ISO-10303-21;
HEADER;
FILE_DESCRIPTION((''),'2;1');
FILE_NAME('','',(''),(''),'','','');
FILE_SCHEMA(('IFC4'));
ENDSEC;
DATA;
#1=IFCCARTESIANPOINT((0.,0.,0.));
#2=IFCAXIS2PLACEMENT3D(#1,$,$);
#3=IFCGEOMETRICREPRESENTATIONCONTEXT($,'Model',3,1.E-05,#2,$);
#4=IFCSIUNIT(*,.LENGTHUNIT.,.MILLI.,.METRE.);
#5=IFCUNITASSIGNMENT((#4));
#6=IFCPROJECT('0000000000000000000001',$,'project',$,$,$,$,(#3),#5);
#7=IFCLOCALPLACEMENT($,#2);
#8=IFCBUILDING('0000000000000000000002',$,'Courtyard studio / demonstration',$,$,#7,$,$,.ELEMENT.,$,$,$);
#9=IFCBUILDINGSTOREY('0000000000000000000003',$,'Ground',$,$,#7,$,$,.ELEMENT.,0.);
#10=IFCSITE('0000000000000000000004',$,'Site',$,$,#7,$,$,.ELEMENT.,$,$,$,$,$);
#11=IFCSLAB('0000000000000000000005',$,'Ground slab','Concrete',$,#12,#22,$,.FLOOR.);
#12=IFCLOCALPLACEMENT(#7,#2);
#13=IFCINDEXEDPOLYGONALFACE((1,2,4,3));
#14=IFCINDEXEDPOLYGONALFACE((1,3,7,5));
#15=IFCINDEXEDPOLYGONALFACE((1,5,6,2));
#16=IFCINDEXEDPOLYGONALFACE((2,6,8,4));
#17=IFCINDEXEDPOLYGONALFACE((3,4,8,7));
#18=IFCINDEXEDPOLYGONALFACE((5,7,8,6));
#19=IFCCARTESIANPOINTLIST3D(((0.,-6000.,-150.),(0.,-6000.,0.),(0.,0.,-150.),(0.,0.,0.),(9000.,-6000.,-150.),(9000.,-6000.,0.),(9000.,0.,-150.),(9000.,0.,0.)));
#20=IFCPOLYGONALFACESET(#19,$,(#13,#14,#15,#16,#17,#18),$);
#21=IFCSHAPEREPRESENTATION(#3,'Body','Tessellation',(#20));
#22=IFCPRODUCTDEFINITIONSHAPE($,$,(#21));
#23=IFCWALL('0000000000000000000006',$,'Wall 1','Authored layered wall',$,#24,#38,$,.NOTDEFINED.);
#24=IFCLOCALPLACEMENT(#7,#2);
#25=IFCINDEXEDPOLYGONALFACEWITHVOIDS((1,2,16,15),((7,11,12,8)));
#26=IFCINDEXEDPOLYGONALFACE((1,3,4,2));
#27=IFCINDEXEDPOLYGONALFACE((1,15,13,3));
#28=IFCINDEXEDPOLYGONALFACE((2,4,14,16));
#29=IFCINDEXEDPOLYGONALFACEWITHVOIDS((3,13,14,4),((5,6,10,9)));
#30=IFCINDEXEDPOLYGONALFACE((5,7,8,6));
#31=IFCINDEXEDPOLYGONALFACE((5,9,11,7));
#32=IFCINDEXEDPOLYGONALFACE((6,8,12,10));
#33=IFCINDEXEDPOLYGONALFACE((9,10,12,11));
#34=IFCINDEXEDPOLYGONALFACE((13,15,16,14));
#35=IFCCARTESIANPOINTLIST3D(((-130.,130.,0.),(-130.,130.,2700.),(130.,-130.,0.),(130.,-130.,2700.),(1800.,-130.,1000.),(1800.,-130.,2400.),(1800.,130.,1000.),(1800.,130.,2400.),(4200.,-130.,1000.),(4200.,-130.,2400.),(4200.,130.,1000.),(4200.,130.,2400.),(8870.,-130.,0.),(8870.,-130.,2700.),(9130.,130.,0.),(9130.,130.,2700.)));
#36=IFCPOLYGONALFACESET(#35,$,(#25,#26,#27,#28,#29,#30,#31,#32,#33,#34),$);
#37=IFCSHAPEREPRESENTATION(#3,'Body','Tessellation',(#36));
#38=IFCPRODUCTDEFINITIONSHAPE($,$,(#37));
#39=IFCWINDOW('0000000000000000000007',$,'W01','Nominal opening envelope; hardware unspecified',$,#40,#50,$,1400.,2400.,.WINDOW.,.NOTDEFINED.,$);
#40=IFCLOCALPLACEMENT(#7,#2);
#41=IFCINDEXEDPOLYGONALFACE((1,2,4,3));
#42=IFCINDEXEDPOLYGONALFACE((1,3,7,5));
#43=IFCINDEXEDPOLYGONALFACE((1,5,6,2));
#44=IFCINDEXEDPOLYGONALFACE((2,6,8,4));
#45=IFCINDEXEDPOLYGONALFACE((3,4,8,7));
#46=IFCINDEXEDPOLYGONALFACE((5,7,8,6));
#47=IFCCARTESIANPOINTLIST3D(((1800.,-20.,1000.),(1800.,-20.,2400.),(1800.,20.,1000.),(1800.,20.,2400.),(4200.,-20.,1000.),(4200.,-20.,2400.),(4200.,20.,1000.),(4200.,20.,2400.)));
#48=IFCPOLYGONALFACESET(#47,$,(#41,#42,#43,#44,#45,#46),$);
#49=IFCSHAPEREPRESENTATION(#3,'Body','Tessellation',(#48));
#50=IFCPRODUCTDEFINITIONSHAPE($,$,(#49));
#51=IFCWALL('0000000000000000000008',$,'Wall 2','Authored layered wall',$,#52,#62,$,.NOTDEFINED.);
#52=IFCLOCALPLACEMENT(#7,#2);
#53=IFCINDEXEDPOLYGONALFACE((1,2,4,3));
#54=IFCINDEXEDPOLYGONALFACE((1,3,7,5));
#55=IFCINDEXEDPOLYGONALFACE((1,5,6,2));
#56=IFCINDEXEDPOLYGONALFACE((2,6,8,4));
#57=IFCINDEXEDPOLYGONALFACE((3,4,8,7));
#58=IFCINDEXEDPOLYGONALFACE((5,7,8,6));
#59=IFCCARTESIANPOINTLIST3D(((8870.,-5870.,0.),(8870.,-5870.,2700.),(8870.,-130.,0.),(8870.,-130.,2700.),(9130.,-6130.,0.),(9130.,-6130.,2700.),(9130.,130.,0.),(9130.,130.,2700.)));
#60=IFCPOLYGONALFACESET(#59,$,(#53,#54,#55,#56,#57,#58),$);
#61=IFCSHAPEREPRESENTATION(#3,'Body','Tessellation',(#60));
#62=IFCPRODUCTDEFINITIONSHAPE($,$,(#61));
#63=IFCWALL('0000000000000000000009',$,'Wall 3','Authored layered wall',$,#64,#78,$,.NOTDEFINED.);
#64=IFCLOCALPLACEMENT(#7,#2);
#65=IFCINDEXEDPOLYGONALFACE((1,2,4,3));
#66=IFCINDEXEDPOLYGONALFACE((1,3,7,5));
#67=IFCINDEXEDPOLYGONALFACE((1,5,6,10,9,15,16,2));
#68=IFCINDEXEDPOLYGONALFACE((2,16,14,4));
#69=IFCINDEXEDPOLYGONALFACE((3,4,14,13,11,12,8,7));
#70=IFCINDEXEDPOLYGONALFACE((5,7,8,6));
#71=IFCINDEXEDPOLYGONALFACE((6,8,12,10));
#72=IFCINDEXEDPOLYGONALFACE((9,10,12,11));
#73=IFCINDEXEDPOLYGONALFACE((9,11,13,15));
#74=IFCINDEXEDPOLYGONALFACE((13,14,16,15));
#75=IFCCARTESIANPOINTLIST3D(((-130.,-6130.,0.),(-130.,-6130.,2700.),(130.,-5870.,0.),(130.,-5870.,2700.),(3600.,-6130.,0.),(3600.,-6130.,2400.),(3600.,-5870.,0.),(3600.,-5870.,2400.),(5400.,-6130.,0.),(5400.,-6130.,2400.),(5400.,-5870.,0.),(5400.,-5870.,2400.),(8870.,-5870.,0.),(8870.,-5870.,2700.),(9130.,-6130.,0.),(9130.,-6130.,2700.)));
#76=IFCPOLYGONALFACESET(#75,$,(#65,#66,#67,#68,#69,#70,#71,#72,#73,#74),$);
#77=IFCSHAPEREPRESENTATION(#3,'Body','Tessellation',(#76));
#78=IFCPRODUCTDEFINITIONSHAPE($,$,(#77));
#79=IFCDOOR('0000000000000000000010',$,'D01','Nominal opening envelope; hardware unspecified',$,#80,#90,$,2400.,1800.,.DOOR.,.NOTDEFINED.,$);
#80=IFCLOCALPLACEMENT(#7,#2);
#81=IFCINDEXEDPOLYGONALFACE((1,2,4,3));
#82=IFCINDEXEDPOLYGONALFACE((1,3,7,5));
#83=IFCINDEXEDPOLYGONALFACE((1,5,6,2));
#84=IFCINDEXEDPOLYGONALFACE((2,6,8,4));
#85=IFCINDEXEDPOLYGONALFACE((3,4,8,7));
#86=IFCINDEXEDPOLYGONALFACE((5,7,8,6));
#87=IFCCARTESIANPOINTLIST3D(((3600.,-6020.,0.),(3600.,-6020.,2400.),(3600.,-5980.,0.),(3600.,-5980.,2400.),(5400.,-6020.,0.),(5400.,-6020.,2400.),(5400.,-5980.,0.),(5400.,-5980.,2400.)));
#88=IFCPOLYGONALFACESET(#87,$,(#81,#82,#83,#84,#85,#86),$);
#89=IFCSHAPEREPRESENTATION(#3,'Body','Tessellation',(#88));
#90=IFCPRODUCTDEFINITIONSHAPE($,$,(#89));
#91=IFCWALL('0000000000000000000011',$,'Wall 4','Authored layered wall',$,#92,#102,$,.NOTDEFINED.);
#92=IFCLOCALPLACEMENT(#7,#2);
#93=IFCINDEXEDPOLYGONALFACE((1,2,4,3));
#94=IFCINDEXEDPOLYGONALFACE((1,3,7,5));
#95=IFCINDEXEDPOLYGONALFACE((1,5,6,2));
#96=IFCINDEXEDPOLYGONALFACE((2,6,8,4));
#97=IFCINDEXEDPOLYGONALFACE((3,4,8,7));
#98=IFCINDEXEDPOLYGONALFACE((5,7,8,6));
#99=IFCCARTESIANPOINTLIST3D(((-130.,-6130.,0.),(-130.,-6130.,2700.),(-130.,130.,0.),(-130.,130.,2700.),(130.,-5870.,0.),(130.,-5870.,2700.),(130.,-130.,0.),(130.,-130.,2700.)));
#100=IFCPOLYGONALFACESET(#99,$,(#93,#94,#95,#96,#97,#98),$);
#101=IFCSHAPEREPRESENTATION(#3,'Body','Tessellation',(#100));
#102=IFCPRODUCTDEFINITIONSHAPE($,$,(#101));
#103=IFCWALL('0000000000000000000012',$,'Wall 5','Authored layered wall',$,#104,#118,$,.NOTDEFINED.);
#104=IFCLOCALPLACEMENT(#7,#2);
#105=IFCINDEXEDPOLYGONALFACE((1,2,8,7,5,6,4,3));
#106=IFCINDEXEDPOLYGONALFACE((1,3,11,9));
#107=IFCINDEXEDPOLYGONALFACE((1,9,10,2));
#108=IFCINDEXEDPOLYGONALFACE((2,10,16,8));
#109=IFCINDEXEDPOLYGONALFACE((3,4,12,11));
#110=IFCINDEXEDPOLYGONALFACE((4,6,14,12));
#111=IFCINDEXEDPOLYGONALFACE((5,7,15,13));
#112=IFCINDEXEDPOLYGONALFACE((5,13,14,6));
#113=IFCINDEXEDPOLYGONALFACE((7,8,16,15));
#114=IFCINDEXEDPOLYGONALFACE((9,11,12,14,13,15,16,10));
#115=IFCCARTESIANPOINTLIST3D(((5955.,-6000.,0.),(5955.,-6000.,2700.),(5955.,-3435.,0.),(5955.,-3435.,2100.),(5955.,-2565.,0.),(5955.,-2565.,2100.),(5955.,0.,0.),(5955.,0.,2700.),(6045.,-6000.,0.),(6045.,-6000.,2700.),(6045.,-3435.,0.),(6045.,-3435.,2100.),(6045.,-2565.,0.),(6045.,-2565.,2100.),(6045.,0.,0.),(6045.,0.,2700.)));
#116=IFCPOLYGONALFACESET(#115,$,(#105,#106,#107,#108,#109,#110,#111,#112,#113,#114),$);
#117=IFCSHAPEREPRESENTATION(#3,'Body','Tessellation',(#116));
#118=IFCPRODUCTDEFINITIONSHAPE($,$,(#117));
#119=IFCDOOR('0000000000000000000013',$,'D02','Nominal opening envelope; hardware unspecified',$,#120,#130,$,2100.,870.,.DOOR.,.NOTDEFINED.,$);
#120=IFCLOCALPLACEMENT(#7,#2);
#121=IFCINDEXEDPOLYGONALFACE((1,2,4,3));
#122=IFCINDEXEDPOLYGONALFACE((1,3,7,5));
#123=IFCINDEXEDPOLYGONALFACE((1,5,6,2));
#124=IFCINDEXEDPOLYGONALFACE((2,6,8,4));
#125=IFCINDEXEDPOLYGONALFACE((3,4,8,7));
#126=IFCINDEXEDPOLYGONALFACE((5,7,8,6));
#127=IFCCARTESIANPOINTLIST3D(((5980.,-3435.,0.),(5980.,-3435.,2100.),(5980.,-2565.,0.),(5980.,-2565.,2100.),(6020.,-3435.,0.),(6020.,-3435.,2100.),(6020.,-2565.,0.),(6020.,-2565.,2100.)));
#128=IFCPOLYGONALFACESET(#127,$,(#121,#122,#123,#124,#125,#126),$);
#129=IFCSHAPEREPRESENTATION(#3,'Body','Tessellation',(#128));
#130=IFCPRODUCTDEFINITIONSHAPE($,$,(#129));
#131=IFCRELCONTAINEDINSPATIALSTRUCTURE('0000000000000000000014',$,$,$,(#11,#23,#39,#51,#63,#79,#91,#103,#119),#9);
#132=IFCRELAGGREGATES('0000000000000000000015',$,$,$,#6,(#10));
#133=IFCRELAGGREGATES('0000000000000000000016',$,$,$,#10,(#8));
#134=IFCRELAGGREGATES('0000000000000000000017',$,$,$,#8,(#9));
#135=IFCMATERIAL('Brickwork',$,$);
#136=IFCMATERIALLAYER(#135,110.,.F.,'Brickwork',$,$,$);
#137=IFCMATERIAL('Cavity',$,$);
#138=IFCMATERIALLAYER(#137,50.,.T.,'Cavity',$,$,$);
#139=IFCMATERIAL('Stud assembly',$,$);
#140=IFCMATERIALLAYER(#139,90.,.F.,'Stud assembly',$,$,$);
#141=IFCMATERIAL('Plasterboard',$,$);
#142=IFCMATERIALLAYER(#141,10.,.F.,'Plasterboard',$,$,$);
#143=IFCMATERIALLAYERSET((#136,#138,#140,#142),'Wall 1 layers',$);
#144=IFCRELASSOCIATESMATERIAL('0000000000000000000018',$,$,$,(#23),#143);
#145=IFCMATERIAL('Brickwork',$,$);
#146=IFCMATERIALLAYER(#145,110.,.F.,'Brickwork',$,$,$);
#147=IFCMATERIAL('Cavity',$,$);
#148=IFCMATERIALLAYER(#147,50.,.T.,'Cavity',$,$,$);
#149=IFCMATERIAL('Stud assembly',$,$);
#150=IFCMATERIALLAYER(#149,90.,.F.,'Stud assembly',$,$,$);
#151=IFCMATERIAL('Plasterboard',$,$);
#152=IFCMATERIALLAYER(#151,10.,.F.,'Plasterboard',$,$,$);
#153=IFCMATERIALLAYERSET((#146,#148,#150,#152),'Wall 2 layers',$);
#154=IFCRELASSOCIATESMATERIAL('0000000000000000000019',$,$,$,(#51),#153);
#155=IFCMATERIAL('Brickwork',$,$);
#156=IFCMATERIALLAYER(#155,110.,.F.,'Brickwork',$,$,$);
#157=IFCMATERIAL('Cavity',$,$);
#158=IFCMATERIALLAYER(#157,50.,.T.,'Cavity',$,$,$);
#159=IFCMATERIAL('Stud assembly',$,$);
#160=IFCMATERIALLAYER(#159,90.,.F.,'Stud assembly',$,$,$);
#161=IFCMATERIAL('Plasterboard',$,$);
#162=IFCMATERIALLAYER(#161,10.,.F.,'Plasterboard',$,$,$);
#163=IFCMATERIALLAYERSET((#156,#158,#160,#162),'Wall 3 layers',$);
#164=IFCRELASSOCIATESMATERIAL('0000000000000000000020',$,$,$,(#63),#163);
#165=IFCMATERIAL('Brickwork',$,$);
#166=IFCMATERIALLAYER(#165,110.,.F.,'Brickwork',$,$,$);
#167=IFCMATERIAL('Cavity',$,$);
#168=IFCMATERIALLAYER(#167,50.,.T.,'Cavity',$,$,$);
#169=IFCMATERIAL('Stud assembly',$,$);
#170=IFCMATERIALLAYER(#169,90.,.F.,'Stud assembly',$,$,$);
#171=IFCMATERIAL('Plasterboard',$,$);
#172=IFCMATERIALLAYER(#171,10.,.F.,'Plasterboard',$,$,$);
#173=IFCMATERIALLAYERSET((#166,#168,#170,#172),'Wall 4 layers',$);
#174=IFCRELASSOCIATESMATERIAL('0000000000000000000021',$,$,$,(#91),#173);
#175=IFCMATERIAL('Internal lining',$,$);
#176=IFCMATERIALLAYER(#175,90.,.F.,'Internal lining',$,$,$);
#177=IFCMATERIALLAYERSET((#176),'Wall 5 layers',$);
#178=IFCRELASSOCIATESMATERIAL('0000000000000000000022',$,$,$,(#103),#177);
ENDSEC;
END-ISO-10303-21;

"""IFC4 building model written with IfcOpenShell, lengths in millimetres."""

from ifc_helpers import new_model, si_unit, frame, origin, place, context, project, spatial, polyline, outline, extrude, material, layer, layer_set, layer_usage, element, fill, save


model = new_model("IFC4")

# Units and contexts
model_context = context("Model", 3, precision=1e-05, world=origin())
ifc_project = project(units=[si_unit("LENGTHUNIT", "METRE", prefix="MILLI")], contexts=[model_context])

# Site, building, storey
placement = place(None, origin())
site = spatial("IfcSite", under=ifc_project, at=placement, Name="Site", CompositionType="ELEMENT")
building = spatial("IfcBuilding", under=site, at=placement, Name="Courtyard studio / demonstration", CompositionType="ELEMENT")
storey = spatial("IfcBuildingStorey", under=building, at=placement, Name="Ground", CompositionType="ELEMENT", Elevation=0.0)

# Slab
element("IfcSlab", 1, at=placement, inside=storey, Name="Ground slab", Description="Concrete", PredefinedType="FLOOR", context=model_context, shape_type="SweptSolid", body=[
    extrude(outline(polyline([(0.0, 0.0), (9000.0, 0.0), (9000.0, -6000.0), (0.0, -6000.0), (0.0, 0.0)])), frame((0.0, 0.0, -150.0)), (0.0, 0.0, 1.0), 150.0),
])

# Wall, opening, window
ifc_material_1 = material(Name="Brickwork")
ifc_layer_1 = layer(ifc_material_1, 110.0, ventilated=False, Name="Brickwork")
ifc_material_2 = material(Name="Cavity")
ifc_layer_2 = layer(ifc_material_2, 50.0, ventilated=True, Name="Cavity")
ifc_material_3 = material(Name="Stud assembly")
ifc_layer_3 = layer(ifc_material_3, 90.0, ventilated=False, Name="Stud assembly")
ifc_material_4 = material(Name="Plasterboard")
ifc_layer_4 = layer(ifc_material_4, 10.0, ventilated=False, Name="Plasterboard")
ifc_layer_set_1 = layer_set([ifc_layer_1, ifc_layer_2, ifc_layer_3, ifc_layer_4], Name="Wall 1 layers")
ifc_layer_usage_1 = layer_usage(ifc_layer_set_1, "AXIS2", "POSITIVE", -130.0)
wall_1 = element("IfcWall", 2, at=placement, inside=storey, material=ifc_layer_usage_1, Name="Wall 1", Description="Authored layered wall", PredefinedType="NOTDEFINED", context=model_context, shape_type="SweptSolid", body=[
    extrude(outline(polyline([(-130.0, 130.0), (9130.0, 130.0), (8870.0, -130.0), (130.0, -130.0), (-130.0, 130.0)])), origin(), (0.0, 0.0, 1.0), 2700.0),
])
opening_1 = element("IfcOpeningElement", 3, at=placement, cuts=wall_1, PredefinedType="OPENING", context=model_context, shape_type="SweptSolid", body=[
    extrude(outline(polyline([(1800.0, 131.0), (4200.0, 131.0), (4200.0, -131.0), (1800.0, -131.0), (1800.0, 131.0)])), frame((0.0, 0.0, 1000.0)), (0.0, 0.0, 1.0), 1400.0),
])
window = element("IfcWindow", 4, at=placement, inside=storey, Name="W01", Description="Nominal opening envelope; hardware unspecified", OverallHeight=1400.0, OverallWidth=2400.0, PartitioningType="NOTDEFINED", PredefinedType="WINDOW", context=model_context, shape_type="SweptSolid", body=[
    extrude(outline(polyline([(1800.0, 20.0), (4200.0, 20.0), (4200.0, -20.0), (1800.0, -20.0), (1800.0, 20.0)])), frame((0.0, 0.0, 1000.0)), (0.0, 0.0, 1.0), 1400.0),
])
fill(opening_1, window)

# Wall
ifc_material_5 = material(Name="Brickwork")
ifc_layer_5 = layer(ifc_material_5, 110.0, ventilated=False, Name="Brickwork")
ifc_material_6 = material(Name="Cavity")
ifc_layer_6 = layer(ifc_material_6, 50.0, ventilated=True, Name="Cavity")
ifc_material_7 = material(Name="Stud assembly")
ifc_layer_7 = layer(ifc_material_7, 90.0, ventilated=False, Name="Stud assembly")
ifc_material_8 = material(Name="Plasterboard")
ifc_layer_8 = layer(ifc_material_8, 10.0, ventilated=False, Name="Plasterboard")
ifc_layer_set_2 = layer_set([ifc_layer_5, ifc_layer_6, ifc_layer_7, ifc_layer_8], Name="Wall 2 layers")
ifc_layer_usage_2 = layer_usage(ifc_layer_set_2, "AXIS2", "POSITIVE", -130.0)
element("IfcWall", 5, at=placement, inside=storey, material=ifc_layer_usage_2, Name="Wall 2", Description="Authored layered wall", PredefinedType="NOTDEFINED", context=model_context, shape_type="SweptSolid", body=[
    extrude(outline(polyline([(9130.0, 130.0), (9130.0, -6130.0), (8870.0, -5870.0), (8870.0, -130.0), (9130.0, 130.0)])), origin(), (0.0, 0.0, 1.0), 2700.0),
])

# Wall, opening, door
ifc_material_9 = material(Name="Brickwork")
ifc_layer_9 = layer(ifc_material_9, 110.0, ventilated=False, Name="Brickwork")
ifc_material_10 = material(Name="Cavity")
ifc_layer_10 = layer(ifc_material_10, 50.0, ventilated=True, Name="Cavity")
ifc_material_11 = material(Name="Stud assembly")
ifc_layer_11 = layer(ifc_material_11, 90.0, ventilated=False, Name="Stud assembly")
ifc_material_12 = material(Name="Plasterboard")
ifc_layer_12 = layer(ifc_material_12, 10.0, ventilated=False, Name="Plasterboard")
ifc_layer_set_3 = layer_set([ifc_layer_9, ifc_layer_10, ifc_layer_11, ifc_layer_12], Name="Wall 3 layers")
ifc_layer_usage_3 = layer_usage(ifc_layer_set_3, "AXIS2", "POSITIVE", -130.0)
wall_2 = element("IfcWall", 6, at=placement, inside=storey, material=ifc_layer_usage_3, Name="Wall 3", Description="Authored layered wall", PredefinedType="NOTDEFINED", context=model_context, shape_type="SweptSolid", body=[
    extrude(outline(polyline([(9130.0, -6130.0), (-130.0, -6130.0), (130.0, -5870.0), (8870.0, -5870.0), (9130.0, -6130.0)])), origin(), (0.0, 0.0, 1.0), 2700.0),
])
opening_2 = element("IfcOpeningElement", 7, at=placement, cuts=wall_2, PredefinedType="OPENING", context=model_context, shape_type="SweptSolid", body=[
    extrude(outline(polyline([(5400.0, -6131.0), (3600.0, -6131.0), (3600.0, -5869.0), (5400.0, -5869.0), (5400.0, -6131.0)])), origin(), (0.0, 0.0, 1.0), 2400.0),
])
door_1 = element("IfcDoor", 8, at=placement, inside=storey, Name="D01", Description="Nominal opening envelope; hardware unspecified", OperationType="NOTDEFINED", OverallHeight=2400.0, OverallWidth=1800.0, PredefinedType="DOOR", context=model_context, shape_type="SweptSolid", body=[
    extrude(outline(polyline([(5400.0, -6020.0), (3600.0, -6020.0), (3600.0, -5980.0), (5400.0, -5980.0), (5400.0, -6020.0)])), origin(), (0.0, 0.0, 1.0), 2400.0),
])
fill(opening_2, door_1)

# Wall
ifc_material_13 = material(Name="Brickwork")
ifc_layer_13 = layer(ifc_material_13, 110.0, ventilated=False, Name="Brickwork")
ifc_material_14 = material(Name="Cavity")
ifc_layer_14 = layer(ifc_material_14, 50.0, ventilated=True, Name="Cavity")
ifc_material_15 = material(Name="Stud assembly")
ifc_layer_15 = layer(ifc_material_15, 90.0, ventilated=False, Name="Stud assembly")
ifc_material_16 = material(Name="Plasterboard")
ifc_layer_16 = layer(ifc_material_16, 10.0, ventilated=False, Name="Plasterboard")
ifc_layer_set_4 = layer_set([ifc_layer_13, ifc_layer_14, ifc_layer_15, ifc_layer_16], Name="Wall 4 layers")
ifc_layer_usage_4 = layer_usage(ifc_layer_set_4, "AXIS2", "POSITIVE", -130.0)
element("IfcWall", 9, at=placement, inside=storey, material=ifc_layer_usage_4, Name="Wall 4", Description="Authored layered wall", PredefinedType="NOTDEFINED", context=model_context, shape_type="SweptSolid", body=[
    extrude(outline(polyline([(-130.0, -6130.0), (-130.0, 130.0), (130.0, -130.0), (130.0, -5870.0), (-130.0, -6130.0)])), origin(), (0.0, 0.0, 1.0), 2700.0),
])

# Wall, opening, door
ifc_material_17 = material(Name="Internal lining")
ifc_layer_17 = layer(ifc_material_17, 90.0, ventilated=False, Name="Internal lining")
ifc_layer_set_5 = layer_set([ifc_layer_17], Name="Wall 5 layers")
ifc_layer_usage_5 = layer_usage(ifc_layer_set_5, "AXIS2", "POSITIVE", -45.0)
wall_3 = element("IfcWall", 10, at=placement, inside=storey, material=ifc_layer_usage_5, Name="Wall 5", Description="Authored layered wall", PredefinedType="NOTDEFINED", context=model_context, shape_type="SweptSolid", body=[
    extrude(outline(polyline([(6045.0, 0.0), (6045.0, -6000.0), (5955.0, -6000.0), (5955.0, 0.0), (6045.0, 0.0)])), origin(), (0.0, 0.0, 1.0), 2700.0),
])
opening_3 = element("IfcOpeningElement", 11, at=placement, cuts=wall_3, PredefinedType="OPENING", context=model_context, shape_type="SweptSolid", body=[
    extrude(outline(polyline([(6046.0, -2565.0), (6046.0, -3435.0), (5954.0, -3435.0), (5954.0, -2565.0), (6046.0, -2565.0)])), origin(), (0.0, 0.0, 1.0), 2100.0),
])
door_2 = element("IfcDoor", 12, at=placement, inside=storey, Name="D02", Description="Nominal opening envelope; hardware unspecified", OperationType="NOTDEFINED", OverallHeight=2100.0, OverallWidth=870.0, PredefinedType="DOOR", context=model_context, shape_type="SweptSolid", body=[
    extrude(outline(polyline([(6020.0, -2565.0), (6020.0, -3435.0), (5980.0, -3435.0), (5980.0, -2565.0), (6020.0, -2565.0)])), origin(), (0.0, 0.0, 1.0), 2100.0),
])
fill(opening_3, door_2)

save(model, "model.ifc")
